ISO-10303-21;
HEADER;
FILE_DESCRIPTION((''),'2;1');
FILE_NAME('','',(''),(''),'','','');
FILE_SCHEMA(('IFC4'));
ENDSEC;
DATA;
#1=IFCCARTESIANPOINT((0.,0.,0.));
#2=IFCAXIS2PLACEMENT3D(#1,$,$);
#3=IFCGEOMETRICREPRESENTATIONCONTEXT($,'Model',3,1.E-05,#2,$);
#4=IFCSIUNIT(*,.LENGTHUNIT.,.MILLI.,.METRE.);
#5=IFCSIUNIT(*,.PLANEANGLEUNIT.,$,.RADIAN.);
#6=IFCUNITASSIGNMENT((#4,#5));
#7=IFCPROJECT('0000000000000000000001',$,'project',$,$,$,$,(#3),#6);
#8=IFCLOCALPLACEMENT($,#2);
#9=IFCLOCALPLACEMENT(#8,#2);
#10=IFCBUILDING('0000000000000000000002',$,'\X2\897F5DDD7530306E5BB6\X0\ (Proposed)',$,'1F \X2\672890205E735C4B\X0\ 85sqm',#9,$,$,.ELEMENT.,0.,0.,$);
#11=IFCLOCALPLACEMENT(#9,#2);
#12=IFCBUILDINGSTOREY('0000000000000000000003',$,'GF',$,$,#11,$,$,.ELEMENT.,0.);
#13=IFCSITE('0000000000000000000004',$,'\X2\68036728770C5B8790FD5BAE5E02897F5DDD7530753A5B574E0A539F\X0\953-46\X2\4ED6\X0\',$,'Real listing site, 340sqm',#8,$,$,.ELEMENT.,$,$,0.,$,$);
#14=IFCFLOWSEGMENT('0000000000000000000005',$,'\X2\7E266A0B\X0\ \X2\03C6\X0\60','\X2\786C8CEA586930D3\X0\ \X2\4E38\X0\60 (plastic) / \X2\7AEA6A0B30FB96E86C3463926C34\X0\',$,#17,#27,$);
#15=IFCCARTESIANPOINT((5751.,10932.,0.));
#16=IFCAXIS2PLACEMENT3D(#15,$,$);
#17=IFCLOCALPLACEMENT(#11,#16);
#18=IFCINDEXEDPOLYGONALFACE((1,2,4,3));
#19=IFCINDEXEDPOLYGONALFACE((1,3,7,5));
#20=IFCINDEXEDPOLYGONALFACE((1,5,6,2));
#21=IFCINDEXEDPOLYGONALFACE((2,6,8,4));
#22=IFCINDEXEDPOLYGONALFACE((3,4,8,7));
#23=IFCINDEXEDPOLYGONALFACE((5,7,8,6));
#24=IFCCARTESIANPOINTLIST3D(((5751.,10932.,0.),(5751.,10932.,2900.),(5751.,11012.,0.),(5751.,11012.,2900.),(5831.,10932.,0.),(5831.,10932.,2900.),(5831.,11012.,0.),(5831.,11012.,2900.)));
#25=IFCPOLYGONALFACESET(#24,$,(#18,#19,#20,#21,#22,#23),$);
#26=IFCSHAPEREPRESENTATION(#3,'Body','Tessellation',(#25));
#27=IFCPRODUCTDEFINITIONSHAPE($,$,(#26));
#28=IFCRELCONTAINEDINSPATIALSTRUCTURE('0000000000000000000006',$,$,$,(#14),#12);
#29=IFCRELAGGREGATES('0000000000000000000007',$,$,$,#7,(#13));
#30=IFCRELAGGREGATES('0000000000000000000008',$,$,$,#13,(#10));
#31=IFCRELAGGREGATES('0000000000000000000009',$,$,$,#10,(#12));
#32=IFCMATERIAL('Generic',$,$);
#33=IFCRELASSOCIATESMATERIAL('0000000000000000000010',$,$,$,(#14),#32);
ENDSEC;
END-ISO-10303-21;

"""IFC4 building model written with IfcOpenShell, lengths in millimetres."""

from ifc_helpers import new_model, si_unit, frame, frame_2d, origin, place, context, project, spatial, rectangle, extrude, material, element, save


model = new_model("IFC4")

# Units and contexts
model_context = context("Model", 3, precision=1e-05, world=origin())
ifc_project = project(units=[si_unit("LENGTHUNIT", "METRE", prefix="MILLI"), si_unit("PLANEANGLEUNIT", "RADIAN")], contexts=[model_context])

# Site, building, storey
site_placement = place(None, origin())
site = spatial("IfcSite", under=ifc_project, at=site_placement, Name="栃木県宇都宮市西川田町字上原953-46他", ObjectType="Real listing site, 340sqm", CompositionType="ELEMENT", RefElevation=0.0)
building_placement = place(site_placement, origin())
building = spatial("IfcBuilding", under=site, at=building_placement, Name="西川田の家 (Proposed)", ObjectType="1F 木造平屋 85sqm", CompositionType="ELEMENT", ElevationOfRefHeight=0.0, ElevationOfTerrain=0.0)
storey_placement = place(building_placement, origin())
storey = spatial("IfcBuildingStorey", under=building, at=storey_placement, Name="GF", CompositionType="ELEMENT", Elevation=0.0)

# Shared definitions
ifc_material_1 = material(Name="Generic")

# Flow segment
flow_segment_1_placement = place(storey_placement, frame((5751.0, 10932.0, 0.0)))
element("IfcFlowSegment", 1, at=flow_segment_1_placement, inside=storey, material=ifc_material_1, Name="縦樋 φ60", Description="硬質塩ビ 丸60 (plastic) / 竪樋・雨水排水", context=model_context, shape_type="SweptSolid", body=[
    extrude(rectangle(XDim=80.0, YDim=80.0, at=frame_2d((40.0, 40.0))), frame((5751.0, 10932.0, 0.0)), (0.0, 0.0, 1.0), 2900.0),
])

save(model, "model.ifc")
